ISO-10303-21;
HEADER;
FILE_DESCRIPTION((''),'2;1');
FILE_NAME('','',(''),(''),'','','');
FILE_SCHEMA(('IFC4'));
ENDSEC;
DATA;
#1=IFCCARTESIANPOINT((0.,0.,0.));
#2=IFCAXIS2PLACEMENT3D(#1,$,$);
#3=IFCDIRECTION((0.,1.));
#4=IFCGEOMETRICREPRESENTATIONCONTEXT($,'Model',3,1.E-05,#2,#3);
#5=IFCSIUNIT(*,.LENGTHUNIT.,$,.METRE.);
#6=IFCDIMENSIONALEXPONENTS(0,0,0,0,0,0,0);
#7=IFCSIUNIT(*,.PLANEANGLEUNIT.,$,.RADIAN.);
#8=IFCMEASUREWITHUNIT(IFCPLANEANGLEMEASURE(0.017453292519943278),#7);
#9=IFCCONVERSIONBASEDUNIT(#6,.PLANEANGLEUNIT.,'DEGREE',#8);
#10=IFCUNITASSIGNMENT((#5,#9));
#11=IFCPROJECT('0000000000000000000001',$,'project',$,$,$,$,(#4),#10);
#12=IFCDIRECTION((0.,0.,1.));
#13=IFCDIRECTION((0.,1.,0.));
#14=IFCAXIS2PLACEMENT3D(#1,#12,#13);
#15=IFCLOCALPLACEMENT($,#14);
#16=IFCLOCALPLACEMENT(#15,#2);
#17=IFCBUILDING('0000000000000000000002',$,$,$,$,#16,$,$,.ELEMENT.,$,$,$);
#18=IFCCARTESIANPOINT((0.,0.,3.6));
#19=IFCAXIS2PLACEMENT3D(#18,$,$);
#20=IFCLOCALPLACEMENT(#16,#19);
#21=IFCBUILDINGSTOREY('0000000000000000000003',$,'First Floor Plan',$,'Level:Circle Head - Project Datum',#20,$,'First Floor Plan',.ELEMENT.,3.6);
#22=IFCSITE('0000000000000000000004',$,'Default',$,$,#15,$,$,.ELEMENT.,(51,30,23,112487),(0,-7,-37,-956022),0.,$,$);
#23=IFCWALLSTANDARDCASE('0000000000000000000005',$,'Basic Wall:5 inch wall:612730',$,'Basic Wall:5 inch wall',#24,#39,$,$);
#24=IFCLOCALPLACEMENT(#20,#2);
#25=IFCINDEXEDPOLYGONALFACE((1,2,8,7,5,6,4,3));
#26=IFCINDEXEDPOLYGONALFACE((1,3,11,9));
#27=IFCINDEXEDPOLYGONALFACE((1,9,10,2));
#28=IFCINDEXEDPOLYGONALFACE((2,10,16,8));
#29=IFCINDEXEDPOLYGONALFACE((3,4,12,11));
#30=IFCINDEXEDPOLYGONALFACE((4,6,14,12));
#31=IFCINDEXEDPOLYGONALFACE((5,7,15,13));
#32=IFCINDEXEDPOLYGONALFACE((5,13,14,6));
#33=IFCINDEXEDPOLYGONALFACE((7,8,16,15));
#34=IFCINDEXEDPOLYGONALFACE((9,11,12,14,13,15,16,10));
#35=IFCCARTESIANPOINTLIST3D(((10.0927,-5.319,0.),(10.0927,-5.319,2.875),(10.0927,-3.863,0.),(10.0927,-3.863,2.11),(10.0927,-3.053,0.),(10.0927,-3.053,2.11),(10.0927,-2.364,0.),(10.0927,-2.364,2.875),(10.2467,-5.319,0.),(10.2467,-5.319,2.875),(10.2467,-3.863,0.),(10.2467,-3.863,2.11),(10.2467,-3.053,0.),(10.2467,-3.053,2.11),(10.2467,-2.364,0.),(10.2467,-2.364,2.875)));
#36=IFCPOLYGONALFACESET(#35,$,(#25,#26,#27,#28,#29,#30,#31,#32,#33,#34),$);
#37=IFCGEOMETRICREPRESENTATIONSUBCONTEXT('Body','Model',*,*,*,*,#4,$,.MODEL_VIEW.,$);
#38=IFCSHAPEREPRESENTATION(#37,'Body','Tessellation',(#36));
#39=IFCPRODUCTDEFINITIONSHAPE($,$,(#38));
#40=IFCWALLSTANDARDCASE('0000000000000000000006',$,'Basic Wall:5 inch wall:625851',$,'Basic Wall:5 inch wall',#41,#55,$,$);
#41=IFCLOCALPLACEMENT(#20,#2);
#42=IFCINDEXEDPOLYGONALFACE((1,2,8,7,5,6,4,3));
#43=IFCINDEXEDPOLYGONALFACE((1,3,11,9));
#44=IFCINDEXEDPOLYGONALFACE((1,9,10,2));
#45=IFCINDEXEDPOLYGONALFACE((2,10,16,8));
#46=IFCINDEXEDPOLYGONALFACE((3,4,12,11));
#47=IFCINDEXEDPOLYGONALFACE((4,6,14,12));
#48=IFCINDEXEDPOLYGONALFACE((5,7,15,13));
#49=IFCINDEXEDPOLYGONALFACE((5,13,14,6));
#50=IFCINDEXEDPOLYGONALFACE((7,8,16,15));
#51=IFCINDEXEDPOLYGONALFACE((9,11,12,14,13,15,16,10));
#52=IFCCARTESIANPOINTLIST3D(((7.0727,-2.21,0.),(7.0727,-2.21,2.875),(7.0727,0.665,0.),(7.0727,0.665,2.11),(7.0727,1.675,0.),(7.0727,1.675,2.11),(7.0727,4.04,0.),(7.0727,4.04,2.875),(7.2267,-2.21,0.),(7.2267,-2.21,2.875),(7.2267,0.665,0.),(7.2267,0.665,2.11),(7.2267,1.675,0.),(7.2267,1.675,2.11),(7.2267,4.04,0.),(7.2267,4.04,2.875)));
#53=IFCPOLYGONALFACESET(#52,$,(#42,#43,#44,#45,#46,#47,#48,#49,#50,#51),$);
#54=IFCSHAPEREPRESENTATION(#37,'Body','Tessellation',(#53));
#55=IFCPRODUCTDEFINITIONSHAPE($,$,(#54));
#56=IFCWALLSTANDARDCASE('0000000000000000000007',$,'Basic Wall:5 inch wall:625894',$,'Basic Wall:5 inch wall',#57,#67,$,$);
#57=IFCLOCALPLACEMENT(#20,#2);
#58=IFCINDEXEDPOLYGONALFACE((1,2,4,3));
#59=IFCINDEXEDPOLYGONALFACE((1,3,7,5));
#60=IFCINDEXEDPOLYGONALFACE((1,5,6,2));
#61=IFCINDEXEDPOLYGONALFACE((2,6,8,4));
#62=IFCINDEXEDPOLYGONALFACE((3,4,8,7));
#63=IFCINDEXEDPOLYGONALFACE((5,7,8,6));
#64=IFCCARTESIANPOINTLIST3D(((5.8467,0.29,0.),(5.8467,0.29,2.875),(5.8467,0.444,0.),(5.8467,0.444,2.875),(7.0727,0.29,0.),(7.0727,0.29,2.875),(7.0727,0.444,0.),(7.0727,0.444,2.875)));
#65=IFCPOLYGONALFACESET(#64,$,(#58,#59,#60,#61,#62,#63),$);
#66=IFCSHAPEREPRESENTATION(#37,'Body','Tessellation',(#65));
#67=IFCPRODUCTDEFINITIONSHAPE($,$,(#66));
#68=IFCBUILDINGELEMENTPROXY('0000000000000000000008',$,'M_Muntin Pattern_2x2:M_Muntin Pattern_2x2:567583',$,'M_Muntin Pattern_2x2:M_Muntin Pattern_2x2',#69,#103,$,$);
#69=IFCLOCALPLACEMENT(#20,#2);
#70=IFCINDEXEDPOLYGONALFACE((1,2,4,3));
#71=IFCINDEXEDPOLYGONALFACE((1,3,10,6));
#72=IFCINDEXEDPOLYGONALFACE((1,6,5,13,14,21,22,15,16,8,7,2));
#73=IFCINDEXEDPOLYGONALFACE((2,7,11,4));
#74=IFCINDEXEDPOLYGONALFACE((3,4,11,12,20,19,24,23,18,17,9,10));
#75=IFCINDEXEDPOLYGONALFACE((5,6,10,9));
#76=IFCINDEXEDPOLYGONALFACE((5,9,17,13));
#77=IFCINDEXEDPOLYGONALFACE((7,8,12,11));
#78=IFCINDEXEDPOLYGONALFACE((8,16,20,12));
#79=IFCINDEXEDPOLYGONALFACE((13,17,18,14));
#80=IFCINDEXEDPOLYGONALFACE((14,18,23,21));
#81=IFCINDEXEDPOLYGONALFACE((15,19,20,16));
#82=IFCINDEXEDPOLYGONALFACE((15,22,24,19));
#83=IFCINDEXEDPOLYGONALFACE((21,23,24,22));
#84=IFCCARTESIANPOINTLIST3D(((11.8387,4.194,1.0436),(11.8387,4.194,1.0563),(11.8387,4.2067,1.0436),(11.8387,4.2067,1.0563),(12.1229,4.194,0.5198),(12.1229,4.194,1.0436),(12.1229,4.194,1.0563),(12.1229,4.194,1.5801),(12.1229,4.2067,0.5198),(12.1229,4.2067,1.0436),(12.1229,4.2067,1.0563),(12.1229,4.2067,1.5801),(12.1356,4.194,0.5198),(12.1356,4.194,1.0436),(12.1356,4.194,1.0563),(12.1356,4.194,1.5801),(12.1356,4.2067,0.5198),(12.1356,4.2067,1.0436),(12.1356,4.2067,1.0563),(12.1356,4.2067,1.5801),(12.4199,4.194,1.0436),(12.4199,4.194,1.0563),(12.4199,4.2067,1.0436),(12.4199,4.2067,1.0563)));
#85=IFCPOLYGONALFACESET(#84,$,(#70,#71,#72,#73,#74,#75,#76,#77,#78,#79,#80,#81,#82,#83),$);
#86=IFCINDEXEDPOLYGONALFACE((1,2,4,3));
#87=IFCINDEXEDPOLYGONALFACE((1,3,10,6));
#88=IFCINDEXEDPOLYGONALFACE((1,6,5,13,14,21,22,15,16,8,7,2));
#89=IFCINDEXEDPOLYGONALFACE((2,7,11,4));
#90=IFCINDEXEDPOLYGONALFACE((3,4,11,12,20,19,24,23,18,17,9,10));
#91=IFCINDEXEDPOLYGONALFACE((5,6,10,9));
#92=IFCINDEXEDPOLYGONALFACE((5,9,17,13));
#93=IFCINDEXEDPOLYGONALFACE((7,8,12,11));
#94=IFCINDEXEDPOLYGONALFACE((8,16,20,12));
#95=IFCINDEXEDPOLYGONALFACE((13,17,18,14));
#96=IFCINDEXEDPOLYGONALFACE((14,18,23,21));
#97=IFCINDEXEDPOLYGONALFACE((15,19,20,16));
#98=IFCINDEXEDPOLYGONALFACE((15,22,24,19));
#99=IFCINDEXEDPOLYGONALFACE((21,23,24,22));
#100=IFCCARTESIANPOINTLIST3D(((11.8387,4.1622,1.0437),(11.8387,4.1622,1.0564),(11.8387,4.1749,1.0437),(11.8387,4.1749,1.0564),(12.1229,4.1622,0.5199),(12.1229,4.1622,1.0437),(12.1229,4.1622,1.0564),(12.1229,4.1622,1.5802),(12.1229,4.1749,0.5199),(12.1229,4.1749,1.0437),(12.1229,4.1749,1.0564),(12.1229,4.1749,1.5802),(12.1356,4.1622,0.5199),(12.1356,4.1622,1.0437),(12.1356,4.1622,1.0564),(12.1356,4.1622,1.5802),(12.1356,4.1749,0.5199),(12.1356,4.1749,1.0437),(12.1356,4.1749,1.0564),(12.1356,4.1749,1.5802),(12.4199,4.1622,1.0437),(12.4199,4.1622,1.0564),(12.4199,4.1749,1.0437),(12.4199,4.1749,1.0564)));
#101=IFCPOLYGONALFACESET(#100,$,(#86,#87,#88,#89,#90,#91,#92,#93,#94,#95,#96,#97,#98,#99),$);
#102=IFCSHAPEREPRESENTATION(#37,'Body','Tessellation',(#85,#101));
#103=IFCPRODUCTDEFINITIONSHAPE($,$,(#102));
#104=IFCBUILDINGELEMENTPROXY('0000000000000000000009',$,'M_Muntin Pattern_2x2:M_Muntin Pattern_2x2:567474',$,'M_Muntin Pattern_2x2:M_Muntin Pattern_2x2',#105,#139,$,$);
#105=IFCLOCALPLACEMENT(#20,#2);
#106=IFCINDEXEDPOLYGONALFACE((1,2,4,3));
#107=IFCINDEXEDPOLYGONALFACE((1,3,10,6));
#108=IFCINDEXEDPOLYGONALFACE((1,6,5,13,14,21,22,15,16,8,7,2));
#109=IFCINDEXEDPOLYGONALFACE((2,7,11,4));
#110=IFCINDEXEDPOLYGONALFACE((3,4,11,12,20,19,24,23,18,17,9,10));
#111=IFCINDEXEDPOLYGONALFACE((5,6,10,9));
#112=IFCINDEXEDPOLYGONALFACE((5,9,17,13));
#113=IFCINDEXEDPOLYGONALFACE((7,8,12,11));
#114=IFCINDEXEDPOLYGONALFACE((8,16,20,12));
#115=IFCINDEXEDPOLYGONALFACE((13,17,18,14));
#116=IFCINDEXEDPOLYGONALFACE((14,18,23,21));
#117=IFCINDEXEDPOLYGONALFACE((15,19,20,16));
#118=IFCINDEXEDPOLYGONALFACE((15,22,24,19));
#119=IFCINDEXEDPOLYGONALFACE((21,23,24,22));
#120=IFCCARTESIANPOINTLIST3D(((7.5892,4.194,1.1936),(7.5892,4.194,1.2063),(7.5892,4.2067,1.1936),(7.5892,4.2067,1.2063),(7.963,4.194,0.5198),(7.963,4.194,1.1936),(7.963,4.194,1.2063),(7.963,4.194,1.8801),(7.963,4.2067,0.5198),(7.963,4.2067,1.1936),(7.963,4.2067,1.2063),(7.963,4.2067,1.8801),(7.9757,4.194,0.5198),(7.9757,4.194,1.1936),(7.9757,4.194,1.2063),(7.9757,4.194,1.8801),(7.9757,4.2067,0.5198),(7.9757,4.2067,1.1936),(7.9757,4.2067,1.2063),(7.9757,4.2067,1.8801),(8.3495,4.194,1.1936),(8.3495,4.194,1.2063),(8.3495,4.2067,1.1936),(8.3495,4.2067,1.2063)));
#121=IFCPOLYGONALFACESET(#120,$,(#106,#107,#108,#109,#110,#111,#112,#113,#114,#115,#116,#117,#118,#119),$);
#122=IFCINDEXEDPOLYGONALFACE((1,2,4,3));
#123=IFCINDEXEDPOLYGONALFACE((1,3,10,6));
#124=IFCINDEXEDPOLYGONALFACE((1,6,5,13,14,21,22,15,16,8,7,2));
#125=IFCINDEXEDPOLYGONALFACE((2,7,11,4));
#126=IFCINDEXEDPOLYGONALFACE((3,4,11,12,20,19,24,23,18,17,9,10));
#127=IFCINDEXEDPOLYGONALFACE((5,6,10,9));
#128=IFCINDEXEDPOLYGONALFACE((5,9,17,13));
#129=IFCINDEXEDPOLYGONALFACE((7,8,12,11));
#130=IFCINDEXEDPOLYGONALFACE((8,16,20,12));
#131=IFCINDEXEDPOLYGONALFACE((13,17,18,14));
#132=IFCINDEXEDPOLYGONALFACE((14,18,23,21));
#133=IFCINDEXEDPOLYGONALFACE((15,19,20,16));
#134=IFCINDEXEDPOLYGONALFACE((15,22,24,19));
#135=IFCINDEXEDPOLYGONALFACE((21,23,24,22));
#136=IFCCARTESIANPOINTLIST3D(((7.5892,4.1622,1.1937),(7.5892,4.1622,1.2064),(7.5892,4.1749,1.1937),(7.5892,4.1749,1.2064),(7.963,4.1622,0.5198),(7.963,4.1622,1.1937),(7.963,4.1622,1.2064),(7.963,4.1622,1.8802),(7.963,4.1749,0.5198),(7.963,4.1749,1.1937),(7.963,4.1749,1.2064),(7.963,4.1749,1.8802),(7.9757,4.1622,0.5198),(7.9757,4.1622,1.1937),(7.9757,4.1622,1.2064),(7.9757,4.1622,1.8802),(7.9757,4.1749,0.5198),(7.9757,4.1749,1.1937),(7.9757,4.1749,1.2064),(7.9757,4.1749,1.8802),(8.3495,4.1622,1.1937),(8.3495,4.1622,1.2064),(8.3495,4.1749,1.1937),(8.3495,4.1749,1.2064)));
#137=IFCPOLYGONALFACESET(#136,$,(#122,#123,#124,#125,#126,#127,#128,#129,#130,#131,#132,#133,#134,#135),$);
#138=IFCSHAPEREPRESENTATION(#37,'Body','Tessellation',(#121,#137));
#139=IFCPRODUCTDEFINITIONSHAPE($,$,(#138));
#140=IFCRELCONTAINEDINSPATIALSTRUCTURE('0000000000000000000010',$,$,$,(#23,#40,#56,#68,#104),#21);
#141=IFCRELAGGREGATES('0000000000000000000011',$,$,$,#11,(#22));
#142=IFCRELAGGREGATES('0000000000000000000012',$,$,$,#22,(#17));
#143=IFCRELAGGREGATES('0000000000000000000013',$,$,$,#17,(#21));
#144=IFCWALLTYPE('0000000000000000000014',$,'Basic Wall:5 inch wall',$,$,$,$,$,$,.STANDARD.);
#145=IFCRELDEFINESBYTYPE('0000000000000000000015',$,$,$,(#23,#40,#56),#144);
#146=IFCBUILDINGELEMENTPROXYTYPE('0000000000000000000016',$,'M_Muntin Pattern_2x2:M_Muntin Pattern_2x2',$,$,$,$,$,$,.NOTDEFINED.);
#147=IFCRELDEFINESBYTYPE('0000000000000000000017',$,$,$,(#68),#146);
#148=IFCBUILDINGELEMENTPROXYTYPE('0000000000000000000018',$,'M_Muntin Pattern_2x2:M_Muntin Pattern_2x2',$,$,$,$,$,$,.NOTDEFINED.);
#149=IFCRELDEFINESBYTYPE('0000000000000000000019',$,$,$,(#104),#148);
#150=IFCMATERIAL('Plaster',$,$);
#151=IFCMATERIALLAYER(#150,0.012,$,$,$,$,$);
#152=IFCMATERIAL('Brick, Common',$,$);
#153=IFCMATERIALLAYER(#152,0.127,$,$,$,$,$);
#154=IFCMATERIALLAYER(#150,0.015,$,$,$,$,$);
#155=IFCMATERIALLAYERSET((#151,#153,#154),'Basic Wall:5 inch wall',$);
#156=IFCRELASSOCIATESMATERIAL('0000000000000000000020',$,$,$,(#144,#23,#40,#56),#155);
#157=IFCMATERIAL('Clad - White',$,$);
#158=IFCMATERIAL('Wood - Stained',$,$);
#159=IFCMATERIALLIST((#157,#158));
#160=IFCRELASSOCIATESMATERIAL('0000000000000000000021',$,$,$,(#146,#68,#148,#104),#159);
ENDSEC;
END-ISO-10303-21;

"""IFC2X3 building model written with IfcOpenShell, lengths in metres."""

from ifc_helpers import new_model, entity, si_unit, converted_unit, direction, frame, frame_2d, origin, place, context, subcontext, project, spatial, polyline, rectangle, outline, extrude, clip, bounded_halfspace, source, transform, mapped, material, material_list, layer, layer_set, layer_usage, type_object, type_shapes, element, save


model = new_model("IFC2X3")

# Units and contexts
model_context = context("Model", 3, precision=1e-05, world=origin(), true_north=direction((0.0, 1.0)))
body_context = subcontext(model_context, "Body", "Model", "MODEL_VIEW")
ifc_project = project(units=[si_unit("LENGTHUNIT", "METRE"), converted_unit("PLANEANGLEUNIT", "DEGREE", entity("IfcPlaneAngleMeasure", 0.017453292519943278), si_unit("PLANEANGLEUNIT", "RADIAN"), dimensions=[0, 0, 0, 0, 0, 0, 0])], contexts=[model_context])

# Site, building, storey
site_placement = place(None, frame((0.0, 0.0, 0.0), z_axis=(0.0, 0.0, 1.0), x_axis=(0.0, 1.0, 0.0)))
site = spatial("IfcSite", under=ifc_project, at=site_placement, Name="Default", CompositionType="ELEMENT", RefLatitude=(51, 30, 23, 112487), RefLongitude=(0, -7, -37, -956022), RefElevation=0.0)
building_placement = place(site_placement, origin())
building = spatial("IfcBuilding", under=site, at=building_placement, CompositionType="ELEMENT")
storey_placement = place(building_placement, frame((0.0, 0.0, 3.6)))
storey = spatial("IfcBuildingStorey", under=building, at=storey_placement, Name="First Floor Plan", ObjectType="Level:Circle Head - Project Datum", LongName="First Floor Plan", CompositionType="ELEMENT", Elevation=3.6)

# Shared definitions
ifc_material_1 = material(Name="Plaster")
ifc_layer_1 = layer(ifc_material_1, 0.012)
ifc_material_2 = material(Name="Brick, Common")
ifc_layer_2 = layer(ifc_material_2, 0.127)
ifc_layer_3 = layer(ifc_material_1, 0.015)
ifc_layer_set_1 = layer_set([ifc_layer_1, ifc_layer_2, ifc_layer_3], Name="Basic Wall:5 inch wall")
wall_type = type_object("IfcWallType", Name="Basic Wall:5 inch wall", PredefinedType="STANDARD", material=ifc_layer_set_1)

# Walls, openings
ifc_layer_usage_1 = layer_usage(ifc_layer_set_1, "AXIS2", "NEGATIVE", 0.077)
wall_1_placement = place(storey_placement, frame((10.1697, -2.364, 0.0), z_axis=(0.0, 0.0, 1.0), x_axis=(0.0, -1.0, 0.0)))
wall_1 = element("IfcWallStandardCase", 1, at=wall_1_placement, inside=storey, type_object=wall_type, material=ifc_layer_usage_1, Name="Basic Wall:5 inch wall:612730", ObjectType="Basic Wall:5 inch wall", context=body_context, shape_type="Clipping", body=[
    clip(extrude(rectangle(XDim=2.955, YDim=0.154, at=frame_2d((1.4775, 0.0), x_axis=(1.0, 0.0))), origin(), (0.0, 0.0, 1.0), 2.875), bounded_halfspace(frame((0.0, -0.077, 2.875), z_axis=(0.0, 0.0, -1.0), x_axis=(1.0, 0.0, 0.0)), True, frame((0.0, -0.077, 2.875)), polyline([(0.0, 0.0), (2.955, 0.0), (2.955, 0.154), (0.0, 0.154), (0.0, 0.0)]))),
])
opening_1_placement = place(wall_1_placement, frame((1.499, 0.077, 0.0)))
element("IfcOpeningElement", 2, at=opening_1_placement, cuts=wall_1, ObjectType="Opening", context=body_context, shape_type="SweptSolid", body=[
    extrude(rectangle(XDim=2.11, YDim=0.81, at=frame_2d((1.055, 0.405), x_axis=(1.0, 0.0))), frame((0.0, 0.0, 0.0), z_axis=(0.0, -1.0, 0.0), x_axis=(0.0, 0.0, 1.0)), (0.0, 0.0, 1.0), 0.154),
])
ifc_layer_usage_2 = layer_usage(ifc_layer_set_1, "AXIS2", "NEGATIVE", 0.077)
wall_2_placement = place(storey_placement, frame((7.1497, 4.04, 0.0), z_axis=(0.0, 0.0, 1.0), x_axis=(0.0, -1.0, 0.0)))
wall_2 = element("IfcWallStandardCase", 3, at=wall_2_placement, inside=storey, type_object=wall_type, material=ifc_layer_usage_2, Name="Basic Wall:5 inch wall:625851", ObjectType="Basic Wall:5 inch wall", context=body_context, shape_type="Clipping", body=[
    clip(extrude(rectangle(XDim=6.25, YDim=0.154, at=frame_2d((3.125, 0.0), x_axis=(1.0, 0.0))), origin(), (0.0, 0.0, 1.0), 2.875), bounded_halfspace(frame((0.0, -0.077, 2.875), z_axis=(0.0, 0.0, -1.0), x_axis=(1.0, 0.0, 0.0)), True, frame((0.0, -0.077, 2.875)), polyline([(0.0, 0.0), (0.359, 0.0), (3.596, 0.0), (3.75, 0.0), (4.509, 0.0), (5.009, 0.0), (6.25, 0.0), (6.25, 0.154), (0.0, 0.154), (0.0, 0.077), (0.0, 0.0)]))),
])
opening_2_placement = place(wall_2_placement, frame((2.365, -0.077, 0.0)))
element("IfcOpeningElement", 4, at=opening_2_placement, cuts=wall_2, ObjectType="Opening", context=body_context, shape_type="SweptSolid", body=[
    extrude(rectangle(XDim=2.11, YDim=1.01, at=frame_2d((1.055, 0.505), x_axis=(1.0, 0.0))), frame((0.0, 0.0, 0.0), z_axis=(0.0, 1.0, 0.0), x_axis=(0.0, 0.0, 1.0)), (0.0, 0.0, 1.0), 0.154),
])

# Wall
ifc_layer_usage_3 = layer_usage(ifc_layer_set_1, "AXIS2", "POSITIVE", -0.077)
wall_3_placement = place(storey_placement, frame((7.0727, 0.367, 0.0), z_axis=(0.0, 0.0, 1.0), x_axis=(-1.0, 0.0, 0.0)))
element("IfcWallStandardCase", 5, at=wall_3_placement, inside=storey, type_object=wall_type, material=ifc_layer_usage_3, Name="Basic Wall:5 inch wall:625894", ObjectType="Basic Wall:5 inch wall", context=body_context, shape_type="Clipping", body=[
    clip(extrude(rectangle(XDim=1.226, YDim=0.154, at=frame_2d((0.613, 0.0), x_axis=(-1.0, 0.0))), origin(), (0.0, 0.0, 1.0), 2.875), bounded_halfspace(frame((0.0, -0.077, 2.875), z_axis=(0.0, 0.0, -1.0), x_axis=(0.0, 1.0, 0.0)), True, frame((0.0, -0.077, 2.875)), polyline([(0.0, 0.0), (1.226, 0.0), (1.226, 0.154), (0.0, 0.154), (0.0, 0.0)]))),
])

# Building element proxies
ifc_material_3 = material(Name="Clad - White")
ifc_material_4 = material(Name="Wood - Stained")
ifc_material_list = material_list([ifc_material_3, ifc_material_4])
building_element_proxy_type_1 = type_object("IfcBuildingElementProxyType", Name="M_Muntin Pattern_2x2:M_Muntin Pattern_2x2", PredefinedType="NOTDEFINED", material=ifc_material_list)
shared_shape_1 = source(origin(), body_context, "Body", "SweptSolid", [
    extrude(outline(polyline([(0.0064, -0.0064), (0.5301, -0.0064), (0.5301, 0.0063), (0.0064, 0.0063), (0.0064, 0.2906), (-0.0063, 0.2906), (-0.0063, 0.0063), (-0.5302, 0.0063), (-0.5302, -0.0064), (-0.0063, -0.0064), (-0.0063, -0.2906), (0.0064, -0.2906), (0.0064, -0.0064)])), frame((0.0, 0.0095, 0.5301), z_axis=(0.0, 1.0, 0.0), x_axis=(0.0, 0.0, 1.0)), (0.0, 0.0, 1.0), 0.0127),
    extrude(outline(polyline([(0.0064, -0.0064), (0.5302, -0.0064), (0.5302, 0.0063), (0.0064, 0.0063), (0.0064, 0.2906), (-0.0063, 0.2906), (-0.0063, 0.0063), (-0.5302, 0.0063), (-0.5302, -0.0064), (-0.0063, -0.0064), (-0.0063, -0.2906), (0.0064, -0.2906), (0.0064, -0.0064)])), frame((0.0, -0.0222, 0.5302), z_axis=(0.0, 1.0, 0.0), x_axis=(0.0, 0.0, 1.0)), (0.0, 0.0, 1.0), 0.0127),
])
type_shapes(building_element_proxy_type_1, [shared_shape_1])
proxy_1_placement = place(storey_placement, frame((12.1293, 4.1845, 0.5199)))
element("IfcBuildingElementProxy", 6, at=proxy_1_placement, inside=storey, type_object=building_element_proxy_type_1, material=ifc_material_list, Name="M_Muntin Pattern_2x2:M_Muntin Pattern_2x2:567583", ObjectType="M_Muntin Pattern_2x2:M_Muntin Pattern_2x2", context=body_context, shape_type="MappedRepresentation", body=[
    mapped(shared_shape_1, transform((0.0, 0.0, 0.0), scale=1.0)),
])
building_element_proxy_type_2 = type_object("IfcBuildingElementProxyType", Name="M_Muntin Pattern_2x2:M_Muntin Pattern_2x2", PredefinedType="NOTDEFINED", material=ifc_material_list)
shared_shape_2 = source(origin(), body_context, "Body", "SweptSolid", [
    extrude(outline(polyline([(0.0064, -0.0064), (0.6801, -0.0064), (0.6801, 0.0063), (0.0064, 0.0063), (0.0064, 0.3802), (-0.0063, 0.3802), (-0.0063, 0.0063), (-0.6802, 0.0063), (-0.6802, -0.0064), (-0.0063, -0.0064), (-0.0063, -0.3801), (0.0064, -0.3801), (0.0064, -0.0064)])), frame((0.0, 0.0095, 0.6801), z_axis=(0.0, 1.0, 0.0), x_axis=(0.0, 0.0, 1.0)), (0.0, 0.0, 1.0), 0.0127),
    extrude(outline(polyline([(0.0064, -0.0064), (0.6802, -0.0064), (0.6802, 0.0063), (0.0064, 0.0063), (0.0064, 0.3802), (-0.0063, 0.3802), (-0.0063, 0.0063), (-0.6802, 0.0063), (-0.6802, -0.0064), (-0.0063, -0.0064), (-0.0063, -0.3801), (0.0064, -0.3801), (0.0064, -0.0064)])), frame((0.0, -0.0222, 0.6802), z_axis=(0.0, 1.0, 0.0), x_axis=(0.0, 0.0, 1.0)), (0.0, 0.0, 1.0), 0.0127),
])
type_shapes(building_element_proxy_type_2, [shared_shape_2])
for number, where, name in (
    (7, (7.9694, 4.1845, 0.5198), "M_Muntin Pattern_2x2:M_Muntin Pattern_2x2:567474"),
):
    element("IfcBuildingElementProxy", number, at=place(storey_placement, frame(where)), inside=storey, type_object=building_element_proxy_type_2, material=ifc_material_list, Name=name, ObjectType="M_Muntin Pattern_2x2:M_Muntin Pattern_2x2", context=body_context, shape_type="MappedRepresentation", body=[
        mapped(shared_shape_2, transform((0.0, 0.0, 0.0), scale=1.0)),
    ])

save(model, "model.ifc")
